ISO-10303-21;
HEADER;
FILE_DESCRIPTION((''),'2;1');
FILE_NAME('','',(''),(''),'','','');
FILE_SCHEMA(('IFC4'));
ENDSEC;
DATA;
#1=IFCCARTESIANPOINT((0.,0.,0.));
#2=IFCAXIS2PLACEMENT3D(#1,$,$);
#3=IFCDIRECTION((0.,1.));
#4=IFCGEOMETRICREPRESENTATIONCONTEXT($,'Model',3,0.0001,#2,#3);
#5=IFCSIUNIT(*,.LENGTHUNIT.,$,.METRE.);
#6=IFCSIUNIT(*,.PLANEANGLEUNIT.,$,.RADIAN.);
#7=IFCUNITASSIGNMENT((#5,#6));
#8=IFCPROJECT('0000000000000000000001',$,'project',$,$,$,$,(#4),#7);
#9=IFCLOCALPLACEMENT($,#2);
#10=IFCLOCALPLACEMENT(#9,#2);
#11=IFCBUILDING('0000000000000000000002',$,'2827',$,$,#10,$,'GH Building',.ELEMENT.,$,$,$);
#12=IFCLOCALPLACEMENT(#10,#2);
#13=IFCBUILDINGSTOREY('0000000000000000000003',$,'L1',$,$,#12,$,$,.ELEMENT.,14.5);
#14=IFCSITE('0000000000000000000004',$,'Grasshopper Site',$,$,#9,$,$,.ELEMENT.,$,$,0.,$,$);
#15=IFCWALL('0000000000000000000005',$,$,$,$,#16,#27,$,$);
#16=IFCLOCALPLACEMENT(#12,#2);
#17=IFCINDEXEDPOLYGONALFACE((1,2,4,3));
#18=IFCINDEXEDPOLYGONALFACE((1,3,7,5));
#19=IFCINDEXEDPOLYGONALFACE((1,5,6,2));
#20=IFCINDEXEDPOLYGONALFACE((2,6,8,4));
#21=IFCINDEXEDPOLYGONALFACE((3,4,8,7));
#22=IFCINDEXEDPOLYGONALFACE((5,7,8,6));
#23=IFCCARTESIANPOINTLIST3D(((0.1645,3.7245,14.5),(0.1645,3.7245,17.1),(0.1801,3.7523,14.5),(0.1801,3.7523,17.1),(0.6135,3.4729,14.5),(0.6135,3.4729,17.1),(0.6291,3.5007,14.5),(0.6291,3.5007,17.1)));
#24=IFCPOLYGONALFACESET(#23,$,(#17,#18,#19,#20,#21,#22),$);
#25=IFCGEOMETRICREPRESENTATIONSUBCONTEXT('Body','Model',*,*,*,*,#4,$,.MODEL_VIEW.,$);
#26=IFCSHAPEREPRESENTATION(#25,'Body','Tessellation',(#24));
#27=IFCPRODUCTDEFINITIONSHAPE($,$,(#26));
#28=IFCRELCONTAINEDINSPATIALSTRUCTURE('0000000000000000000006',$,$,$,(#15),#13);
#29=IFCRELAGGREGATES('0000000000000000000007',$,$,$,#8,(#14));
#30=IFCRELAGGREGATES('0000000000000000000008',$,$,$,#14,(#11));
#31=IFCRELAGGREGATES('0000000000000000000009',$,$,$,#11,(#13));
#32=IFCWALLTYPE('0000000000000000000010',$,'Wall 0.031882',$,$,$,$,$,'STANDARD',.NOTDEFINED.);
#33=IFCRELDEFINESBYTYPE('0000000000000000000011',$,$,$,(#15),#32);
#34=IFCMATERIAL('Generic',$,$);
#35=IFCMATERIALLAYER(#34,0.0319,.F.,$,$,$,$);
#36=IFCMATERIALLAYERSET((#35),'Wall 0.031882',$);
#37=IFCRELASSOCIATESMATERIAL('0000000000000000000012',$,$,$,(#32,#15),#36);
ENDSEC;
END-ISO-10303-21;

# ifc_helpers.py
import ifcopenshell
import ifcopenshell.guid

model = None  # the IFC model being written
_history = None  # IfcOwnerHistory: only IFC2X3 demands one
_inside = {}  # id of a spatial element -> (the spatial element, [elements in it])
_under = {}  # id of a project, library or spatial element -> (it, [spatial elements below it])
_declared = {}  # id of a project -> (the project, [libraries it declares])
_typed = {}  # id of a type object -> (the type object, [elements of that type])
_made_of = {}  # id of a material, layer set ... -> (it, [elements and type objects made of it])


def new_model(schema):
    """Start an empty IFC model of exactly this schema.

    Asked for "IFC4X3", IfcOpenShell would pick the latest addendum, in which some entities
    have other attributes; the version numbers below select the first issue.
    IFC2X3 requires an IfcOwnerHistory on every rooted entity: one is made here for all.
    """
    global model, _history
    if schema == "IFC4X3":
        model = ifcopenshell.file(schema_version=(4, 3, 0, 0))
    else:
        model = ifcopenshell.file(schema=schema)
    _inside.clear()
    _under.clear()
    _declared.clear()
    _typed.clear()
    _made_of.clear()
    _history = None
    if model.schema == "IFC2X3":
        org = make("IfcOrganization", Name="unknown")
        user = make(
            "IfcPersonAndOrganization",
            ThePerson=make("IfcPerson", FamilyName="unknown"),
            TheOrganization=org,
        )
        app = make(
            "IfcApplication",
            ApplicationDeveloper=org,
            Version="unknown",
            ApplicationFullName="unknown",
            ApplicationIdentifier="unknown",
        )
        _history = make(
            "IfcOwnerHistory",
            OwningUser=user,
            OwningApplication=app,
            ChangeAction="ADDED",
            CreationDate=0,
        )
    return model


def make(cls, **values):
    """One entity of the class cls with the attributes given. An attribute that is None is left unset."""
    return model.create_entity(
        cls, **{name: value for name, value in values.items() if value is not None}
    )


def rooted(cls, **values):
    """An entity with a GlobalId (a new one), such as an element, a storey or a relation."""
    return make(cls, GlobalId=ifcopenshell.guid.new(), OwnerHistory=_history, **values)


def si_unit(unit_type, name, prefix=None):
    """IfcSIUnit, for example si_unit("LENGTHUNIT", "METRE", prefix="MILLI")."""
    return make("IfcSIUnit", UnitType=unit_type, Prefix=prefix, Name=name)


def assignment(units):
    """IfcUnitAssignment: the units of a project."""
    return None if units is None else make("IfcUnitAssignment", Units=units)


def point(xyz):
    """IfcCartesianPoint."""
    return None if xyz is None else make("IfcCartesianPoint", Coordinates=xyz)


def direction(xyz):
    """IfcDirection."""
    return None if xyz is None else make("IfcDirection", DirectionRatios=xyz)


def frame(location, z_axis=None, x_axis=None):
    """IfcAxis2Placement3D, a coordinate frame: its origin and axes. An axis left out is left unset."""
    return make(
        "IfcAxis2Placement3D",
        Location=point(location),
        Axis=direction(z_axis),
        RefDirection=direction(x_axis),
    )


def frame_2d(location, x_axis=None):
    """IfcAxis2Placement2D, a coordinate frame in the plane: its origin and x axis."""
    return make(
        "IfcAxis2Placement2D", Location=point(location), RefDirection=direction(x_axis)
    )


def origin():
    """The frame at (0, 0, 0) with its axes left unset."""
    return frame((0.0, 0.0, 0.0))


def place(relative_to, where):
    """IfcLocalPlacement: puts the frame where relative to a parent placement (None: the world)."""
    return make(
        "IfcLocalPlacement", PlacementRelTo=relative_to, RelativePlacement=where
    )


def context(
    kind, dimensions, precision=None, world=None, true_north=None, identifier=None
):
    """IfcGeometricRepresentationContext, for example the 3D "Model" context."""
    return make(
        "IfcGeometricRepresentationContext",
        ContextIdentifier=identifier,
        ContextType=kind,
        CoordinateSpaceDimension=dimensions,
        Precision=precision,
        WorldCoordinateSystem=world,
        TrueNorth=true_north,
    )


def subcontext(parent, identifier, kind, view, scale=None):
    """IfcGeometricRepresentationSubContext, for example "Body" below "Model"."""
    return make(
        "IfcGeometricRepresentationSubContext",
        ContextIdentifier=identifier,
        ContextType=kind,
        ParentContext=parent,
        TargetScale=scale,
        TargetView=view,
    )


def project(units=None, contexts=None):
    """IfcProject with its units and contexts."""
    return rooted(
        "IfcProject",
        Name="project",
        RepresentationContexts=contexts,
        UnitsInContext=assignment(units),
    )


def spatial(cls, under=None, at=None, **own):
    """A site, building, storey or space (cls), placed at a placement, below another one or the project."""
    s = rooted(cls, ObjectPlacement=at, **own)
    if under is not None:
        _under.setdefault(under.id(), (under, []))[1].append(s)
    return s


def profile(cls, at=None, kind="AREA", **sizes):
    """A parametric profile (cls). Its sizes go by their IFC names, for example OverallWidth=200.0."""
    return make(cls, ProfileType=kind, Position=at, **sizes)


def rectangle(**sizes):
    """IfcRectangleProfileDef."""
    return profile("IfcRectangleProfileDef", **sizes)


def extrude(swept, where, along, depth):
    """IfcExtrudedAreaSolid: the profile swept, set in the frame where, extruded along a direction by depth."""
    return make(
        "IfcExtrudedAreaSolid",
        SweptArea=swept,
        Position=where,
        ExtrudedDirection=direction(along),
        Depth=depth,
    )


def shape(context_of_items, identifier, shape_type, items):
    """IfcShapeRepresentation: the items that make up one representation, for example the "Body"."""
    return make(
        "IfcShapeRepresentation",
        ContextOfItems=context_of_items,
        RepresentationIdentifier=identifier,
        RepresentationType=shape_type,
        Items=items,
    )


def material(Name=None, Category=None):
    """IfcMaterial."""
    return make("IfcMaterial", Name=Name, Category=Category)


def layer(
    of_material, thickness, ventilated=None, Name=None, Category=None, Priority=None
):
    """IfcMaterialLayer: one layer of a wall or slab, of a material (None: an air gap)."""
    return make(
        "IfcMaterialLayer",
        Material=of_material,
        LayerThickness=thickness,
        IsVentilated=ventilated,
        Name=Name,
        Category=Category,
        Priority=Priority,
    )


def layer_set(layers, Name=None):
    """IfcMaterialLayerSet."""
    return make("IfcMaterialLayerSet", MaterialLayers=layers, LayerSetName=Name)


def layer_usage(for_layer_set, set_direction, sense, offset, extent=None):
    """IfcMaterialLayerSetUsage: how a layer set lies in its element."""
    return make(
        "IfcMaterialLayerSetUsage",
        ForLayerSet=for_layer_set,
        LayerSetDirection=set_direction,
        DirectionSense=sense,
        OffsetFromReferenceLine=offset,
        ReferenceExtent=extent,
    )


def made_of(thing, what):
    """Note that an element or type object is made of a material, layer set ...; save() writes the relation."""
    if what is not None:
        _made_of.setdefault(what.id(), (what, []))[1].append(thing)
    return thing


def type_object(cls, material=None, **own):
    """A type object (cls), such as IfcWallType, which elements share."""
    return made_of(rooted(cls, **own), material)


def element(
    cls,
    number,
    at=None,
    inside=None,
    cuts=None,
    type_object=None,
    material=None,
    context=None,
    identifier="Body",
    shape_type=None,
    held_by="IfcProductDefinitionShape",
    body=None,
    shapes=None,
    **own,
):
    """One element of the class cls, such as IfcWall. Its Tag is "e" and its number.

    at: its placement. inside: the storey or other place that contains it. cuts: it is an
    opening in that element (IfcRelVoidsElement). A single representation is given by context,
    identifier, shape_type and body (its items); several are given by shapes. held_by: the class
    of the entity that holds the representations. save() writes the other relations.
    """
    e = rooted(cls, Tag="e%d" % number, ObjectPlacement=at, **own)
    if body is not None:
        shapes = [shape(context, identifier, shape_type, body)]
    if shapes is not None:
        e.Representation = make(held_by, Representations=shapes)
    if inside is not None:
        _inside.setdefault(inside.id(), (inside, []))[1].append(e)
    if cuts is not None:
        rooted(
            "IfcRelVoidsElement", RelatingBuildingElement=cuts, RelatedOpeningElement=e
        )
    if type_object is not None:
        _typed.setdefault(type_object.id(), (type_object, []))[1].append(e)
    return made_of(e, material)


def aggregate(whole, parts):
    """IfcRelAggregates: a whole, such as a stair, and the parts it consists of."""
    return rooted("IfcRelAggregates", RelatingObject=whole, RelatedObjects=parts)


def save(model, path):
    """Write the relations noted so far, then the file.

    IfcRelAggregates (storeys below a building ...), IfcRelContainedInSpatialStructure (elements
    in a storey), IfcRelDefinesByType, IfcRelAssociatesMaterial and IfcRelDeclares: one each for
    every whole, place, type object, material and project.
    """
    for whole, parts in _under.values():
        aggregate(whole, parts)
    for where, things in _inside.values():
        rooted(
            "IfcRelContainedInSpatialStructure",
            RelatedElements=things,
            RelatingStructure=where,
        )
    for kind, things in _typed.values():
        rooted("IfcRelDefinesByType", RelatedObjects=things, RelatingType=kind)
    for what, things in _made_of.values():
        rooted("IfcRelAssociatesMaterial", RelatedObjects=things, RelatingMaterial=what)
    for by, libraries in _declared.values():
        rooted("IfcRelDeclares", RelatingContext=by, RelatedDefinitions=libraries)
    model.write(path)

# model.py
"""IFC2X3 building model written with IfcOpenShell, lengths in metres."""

from ifc_helpers import new_model, si_unit, direction, frame, frame_2d, origin, place, context, subcontext, project, spatial, rectangle, extrude, material, layer, layer_set, layer_usage, type_object, element, save


model = new_model("IFC2X3")

# Units and contexts
model_context = context("Model", 3, precision=0.0001, world=origin(), true_north=direction((0.0, 1.0)))
body_context = subcontext(model_context, "Body", "Model", "MODEL_VIEW")
ifc_project = project(units=[si_unit("LENGTHUNIT", "METRE"), si_unit("PLANEANGLEUNIT", "RADIAN")], contexts=[model_context])

# Site, building, storey
site_placement = place(None, origin())
site = spatial("IfcSite", under=ifc_project, at=site_placement, Name="Grasshopper Site", CompositionType="ELEMENT", RefElevation=0.0)
building_placement = place(site_placement, origin())
building = spatial("IfcBuilding", under=site, at=building_placement, Name="2827", LongName="GH Building", CompositionType="ELEMENT")
storey_placement = place(building_placement, origin())
storey = spatial("IfcBuildingStorey", under=building, at=storey_placement, Name="L1", CompositionType="ELEMENT", Elevation=14.5)

# Shared definitions
ifc_material = material(Name="Generic")

# Wall
ifc_layer_1 = layer(ifc_material, 0.0319, ventilated=False)
ifc_layer_set_1 = layer_set([ifc_layer_1], Name="Wall 0.031882")
ifc_layer_usage_1 = layer_usage(ifc_layer_set_1, "AXIS2", "NEGATIVE", 0.0159)
wall_type_1 = type_object("IfcWallType", Name="Wall 0.031882", ElementType="STANDARD", PredefinedType="NOTDEFINED", material=ifc_layer_set_1)
wall_1_placement = place(storey_placement, frame((0.1723, 3.7384, 14.5), z_axis=(0.0, 0.0, 1.0), x_axis=(0.872406, -0.488782, 0.0)))
element("IfcWall", 1, at=wall_1_placement, inside=storey, type_object=wall_type_1, material=ifc_layer_usage_1, context=body_context, shape_type="SweptSolid", body=[
    extrude(rectangle(XDim=0.5147, YDim=0.0319, at=frame_2d((0.2573, 0.0))), origin(), (0.0, 0.0, 1.0), 2.6),
])

save(model, "model.ifc")
